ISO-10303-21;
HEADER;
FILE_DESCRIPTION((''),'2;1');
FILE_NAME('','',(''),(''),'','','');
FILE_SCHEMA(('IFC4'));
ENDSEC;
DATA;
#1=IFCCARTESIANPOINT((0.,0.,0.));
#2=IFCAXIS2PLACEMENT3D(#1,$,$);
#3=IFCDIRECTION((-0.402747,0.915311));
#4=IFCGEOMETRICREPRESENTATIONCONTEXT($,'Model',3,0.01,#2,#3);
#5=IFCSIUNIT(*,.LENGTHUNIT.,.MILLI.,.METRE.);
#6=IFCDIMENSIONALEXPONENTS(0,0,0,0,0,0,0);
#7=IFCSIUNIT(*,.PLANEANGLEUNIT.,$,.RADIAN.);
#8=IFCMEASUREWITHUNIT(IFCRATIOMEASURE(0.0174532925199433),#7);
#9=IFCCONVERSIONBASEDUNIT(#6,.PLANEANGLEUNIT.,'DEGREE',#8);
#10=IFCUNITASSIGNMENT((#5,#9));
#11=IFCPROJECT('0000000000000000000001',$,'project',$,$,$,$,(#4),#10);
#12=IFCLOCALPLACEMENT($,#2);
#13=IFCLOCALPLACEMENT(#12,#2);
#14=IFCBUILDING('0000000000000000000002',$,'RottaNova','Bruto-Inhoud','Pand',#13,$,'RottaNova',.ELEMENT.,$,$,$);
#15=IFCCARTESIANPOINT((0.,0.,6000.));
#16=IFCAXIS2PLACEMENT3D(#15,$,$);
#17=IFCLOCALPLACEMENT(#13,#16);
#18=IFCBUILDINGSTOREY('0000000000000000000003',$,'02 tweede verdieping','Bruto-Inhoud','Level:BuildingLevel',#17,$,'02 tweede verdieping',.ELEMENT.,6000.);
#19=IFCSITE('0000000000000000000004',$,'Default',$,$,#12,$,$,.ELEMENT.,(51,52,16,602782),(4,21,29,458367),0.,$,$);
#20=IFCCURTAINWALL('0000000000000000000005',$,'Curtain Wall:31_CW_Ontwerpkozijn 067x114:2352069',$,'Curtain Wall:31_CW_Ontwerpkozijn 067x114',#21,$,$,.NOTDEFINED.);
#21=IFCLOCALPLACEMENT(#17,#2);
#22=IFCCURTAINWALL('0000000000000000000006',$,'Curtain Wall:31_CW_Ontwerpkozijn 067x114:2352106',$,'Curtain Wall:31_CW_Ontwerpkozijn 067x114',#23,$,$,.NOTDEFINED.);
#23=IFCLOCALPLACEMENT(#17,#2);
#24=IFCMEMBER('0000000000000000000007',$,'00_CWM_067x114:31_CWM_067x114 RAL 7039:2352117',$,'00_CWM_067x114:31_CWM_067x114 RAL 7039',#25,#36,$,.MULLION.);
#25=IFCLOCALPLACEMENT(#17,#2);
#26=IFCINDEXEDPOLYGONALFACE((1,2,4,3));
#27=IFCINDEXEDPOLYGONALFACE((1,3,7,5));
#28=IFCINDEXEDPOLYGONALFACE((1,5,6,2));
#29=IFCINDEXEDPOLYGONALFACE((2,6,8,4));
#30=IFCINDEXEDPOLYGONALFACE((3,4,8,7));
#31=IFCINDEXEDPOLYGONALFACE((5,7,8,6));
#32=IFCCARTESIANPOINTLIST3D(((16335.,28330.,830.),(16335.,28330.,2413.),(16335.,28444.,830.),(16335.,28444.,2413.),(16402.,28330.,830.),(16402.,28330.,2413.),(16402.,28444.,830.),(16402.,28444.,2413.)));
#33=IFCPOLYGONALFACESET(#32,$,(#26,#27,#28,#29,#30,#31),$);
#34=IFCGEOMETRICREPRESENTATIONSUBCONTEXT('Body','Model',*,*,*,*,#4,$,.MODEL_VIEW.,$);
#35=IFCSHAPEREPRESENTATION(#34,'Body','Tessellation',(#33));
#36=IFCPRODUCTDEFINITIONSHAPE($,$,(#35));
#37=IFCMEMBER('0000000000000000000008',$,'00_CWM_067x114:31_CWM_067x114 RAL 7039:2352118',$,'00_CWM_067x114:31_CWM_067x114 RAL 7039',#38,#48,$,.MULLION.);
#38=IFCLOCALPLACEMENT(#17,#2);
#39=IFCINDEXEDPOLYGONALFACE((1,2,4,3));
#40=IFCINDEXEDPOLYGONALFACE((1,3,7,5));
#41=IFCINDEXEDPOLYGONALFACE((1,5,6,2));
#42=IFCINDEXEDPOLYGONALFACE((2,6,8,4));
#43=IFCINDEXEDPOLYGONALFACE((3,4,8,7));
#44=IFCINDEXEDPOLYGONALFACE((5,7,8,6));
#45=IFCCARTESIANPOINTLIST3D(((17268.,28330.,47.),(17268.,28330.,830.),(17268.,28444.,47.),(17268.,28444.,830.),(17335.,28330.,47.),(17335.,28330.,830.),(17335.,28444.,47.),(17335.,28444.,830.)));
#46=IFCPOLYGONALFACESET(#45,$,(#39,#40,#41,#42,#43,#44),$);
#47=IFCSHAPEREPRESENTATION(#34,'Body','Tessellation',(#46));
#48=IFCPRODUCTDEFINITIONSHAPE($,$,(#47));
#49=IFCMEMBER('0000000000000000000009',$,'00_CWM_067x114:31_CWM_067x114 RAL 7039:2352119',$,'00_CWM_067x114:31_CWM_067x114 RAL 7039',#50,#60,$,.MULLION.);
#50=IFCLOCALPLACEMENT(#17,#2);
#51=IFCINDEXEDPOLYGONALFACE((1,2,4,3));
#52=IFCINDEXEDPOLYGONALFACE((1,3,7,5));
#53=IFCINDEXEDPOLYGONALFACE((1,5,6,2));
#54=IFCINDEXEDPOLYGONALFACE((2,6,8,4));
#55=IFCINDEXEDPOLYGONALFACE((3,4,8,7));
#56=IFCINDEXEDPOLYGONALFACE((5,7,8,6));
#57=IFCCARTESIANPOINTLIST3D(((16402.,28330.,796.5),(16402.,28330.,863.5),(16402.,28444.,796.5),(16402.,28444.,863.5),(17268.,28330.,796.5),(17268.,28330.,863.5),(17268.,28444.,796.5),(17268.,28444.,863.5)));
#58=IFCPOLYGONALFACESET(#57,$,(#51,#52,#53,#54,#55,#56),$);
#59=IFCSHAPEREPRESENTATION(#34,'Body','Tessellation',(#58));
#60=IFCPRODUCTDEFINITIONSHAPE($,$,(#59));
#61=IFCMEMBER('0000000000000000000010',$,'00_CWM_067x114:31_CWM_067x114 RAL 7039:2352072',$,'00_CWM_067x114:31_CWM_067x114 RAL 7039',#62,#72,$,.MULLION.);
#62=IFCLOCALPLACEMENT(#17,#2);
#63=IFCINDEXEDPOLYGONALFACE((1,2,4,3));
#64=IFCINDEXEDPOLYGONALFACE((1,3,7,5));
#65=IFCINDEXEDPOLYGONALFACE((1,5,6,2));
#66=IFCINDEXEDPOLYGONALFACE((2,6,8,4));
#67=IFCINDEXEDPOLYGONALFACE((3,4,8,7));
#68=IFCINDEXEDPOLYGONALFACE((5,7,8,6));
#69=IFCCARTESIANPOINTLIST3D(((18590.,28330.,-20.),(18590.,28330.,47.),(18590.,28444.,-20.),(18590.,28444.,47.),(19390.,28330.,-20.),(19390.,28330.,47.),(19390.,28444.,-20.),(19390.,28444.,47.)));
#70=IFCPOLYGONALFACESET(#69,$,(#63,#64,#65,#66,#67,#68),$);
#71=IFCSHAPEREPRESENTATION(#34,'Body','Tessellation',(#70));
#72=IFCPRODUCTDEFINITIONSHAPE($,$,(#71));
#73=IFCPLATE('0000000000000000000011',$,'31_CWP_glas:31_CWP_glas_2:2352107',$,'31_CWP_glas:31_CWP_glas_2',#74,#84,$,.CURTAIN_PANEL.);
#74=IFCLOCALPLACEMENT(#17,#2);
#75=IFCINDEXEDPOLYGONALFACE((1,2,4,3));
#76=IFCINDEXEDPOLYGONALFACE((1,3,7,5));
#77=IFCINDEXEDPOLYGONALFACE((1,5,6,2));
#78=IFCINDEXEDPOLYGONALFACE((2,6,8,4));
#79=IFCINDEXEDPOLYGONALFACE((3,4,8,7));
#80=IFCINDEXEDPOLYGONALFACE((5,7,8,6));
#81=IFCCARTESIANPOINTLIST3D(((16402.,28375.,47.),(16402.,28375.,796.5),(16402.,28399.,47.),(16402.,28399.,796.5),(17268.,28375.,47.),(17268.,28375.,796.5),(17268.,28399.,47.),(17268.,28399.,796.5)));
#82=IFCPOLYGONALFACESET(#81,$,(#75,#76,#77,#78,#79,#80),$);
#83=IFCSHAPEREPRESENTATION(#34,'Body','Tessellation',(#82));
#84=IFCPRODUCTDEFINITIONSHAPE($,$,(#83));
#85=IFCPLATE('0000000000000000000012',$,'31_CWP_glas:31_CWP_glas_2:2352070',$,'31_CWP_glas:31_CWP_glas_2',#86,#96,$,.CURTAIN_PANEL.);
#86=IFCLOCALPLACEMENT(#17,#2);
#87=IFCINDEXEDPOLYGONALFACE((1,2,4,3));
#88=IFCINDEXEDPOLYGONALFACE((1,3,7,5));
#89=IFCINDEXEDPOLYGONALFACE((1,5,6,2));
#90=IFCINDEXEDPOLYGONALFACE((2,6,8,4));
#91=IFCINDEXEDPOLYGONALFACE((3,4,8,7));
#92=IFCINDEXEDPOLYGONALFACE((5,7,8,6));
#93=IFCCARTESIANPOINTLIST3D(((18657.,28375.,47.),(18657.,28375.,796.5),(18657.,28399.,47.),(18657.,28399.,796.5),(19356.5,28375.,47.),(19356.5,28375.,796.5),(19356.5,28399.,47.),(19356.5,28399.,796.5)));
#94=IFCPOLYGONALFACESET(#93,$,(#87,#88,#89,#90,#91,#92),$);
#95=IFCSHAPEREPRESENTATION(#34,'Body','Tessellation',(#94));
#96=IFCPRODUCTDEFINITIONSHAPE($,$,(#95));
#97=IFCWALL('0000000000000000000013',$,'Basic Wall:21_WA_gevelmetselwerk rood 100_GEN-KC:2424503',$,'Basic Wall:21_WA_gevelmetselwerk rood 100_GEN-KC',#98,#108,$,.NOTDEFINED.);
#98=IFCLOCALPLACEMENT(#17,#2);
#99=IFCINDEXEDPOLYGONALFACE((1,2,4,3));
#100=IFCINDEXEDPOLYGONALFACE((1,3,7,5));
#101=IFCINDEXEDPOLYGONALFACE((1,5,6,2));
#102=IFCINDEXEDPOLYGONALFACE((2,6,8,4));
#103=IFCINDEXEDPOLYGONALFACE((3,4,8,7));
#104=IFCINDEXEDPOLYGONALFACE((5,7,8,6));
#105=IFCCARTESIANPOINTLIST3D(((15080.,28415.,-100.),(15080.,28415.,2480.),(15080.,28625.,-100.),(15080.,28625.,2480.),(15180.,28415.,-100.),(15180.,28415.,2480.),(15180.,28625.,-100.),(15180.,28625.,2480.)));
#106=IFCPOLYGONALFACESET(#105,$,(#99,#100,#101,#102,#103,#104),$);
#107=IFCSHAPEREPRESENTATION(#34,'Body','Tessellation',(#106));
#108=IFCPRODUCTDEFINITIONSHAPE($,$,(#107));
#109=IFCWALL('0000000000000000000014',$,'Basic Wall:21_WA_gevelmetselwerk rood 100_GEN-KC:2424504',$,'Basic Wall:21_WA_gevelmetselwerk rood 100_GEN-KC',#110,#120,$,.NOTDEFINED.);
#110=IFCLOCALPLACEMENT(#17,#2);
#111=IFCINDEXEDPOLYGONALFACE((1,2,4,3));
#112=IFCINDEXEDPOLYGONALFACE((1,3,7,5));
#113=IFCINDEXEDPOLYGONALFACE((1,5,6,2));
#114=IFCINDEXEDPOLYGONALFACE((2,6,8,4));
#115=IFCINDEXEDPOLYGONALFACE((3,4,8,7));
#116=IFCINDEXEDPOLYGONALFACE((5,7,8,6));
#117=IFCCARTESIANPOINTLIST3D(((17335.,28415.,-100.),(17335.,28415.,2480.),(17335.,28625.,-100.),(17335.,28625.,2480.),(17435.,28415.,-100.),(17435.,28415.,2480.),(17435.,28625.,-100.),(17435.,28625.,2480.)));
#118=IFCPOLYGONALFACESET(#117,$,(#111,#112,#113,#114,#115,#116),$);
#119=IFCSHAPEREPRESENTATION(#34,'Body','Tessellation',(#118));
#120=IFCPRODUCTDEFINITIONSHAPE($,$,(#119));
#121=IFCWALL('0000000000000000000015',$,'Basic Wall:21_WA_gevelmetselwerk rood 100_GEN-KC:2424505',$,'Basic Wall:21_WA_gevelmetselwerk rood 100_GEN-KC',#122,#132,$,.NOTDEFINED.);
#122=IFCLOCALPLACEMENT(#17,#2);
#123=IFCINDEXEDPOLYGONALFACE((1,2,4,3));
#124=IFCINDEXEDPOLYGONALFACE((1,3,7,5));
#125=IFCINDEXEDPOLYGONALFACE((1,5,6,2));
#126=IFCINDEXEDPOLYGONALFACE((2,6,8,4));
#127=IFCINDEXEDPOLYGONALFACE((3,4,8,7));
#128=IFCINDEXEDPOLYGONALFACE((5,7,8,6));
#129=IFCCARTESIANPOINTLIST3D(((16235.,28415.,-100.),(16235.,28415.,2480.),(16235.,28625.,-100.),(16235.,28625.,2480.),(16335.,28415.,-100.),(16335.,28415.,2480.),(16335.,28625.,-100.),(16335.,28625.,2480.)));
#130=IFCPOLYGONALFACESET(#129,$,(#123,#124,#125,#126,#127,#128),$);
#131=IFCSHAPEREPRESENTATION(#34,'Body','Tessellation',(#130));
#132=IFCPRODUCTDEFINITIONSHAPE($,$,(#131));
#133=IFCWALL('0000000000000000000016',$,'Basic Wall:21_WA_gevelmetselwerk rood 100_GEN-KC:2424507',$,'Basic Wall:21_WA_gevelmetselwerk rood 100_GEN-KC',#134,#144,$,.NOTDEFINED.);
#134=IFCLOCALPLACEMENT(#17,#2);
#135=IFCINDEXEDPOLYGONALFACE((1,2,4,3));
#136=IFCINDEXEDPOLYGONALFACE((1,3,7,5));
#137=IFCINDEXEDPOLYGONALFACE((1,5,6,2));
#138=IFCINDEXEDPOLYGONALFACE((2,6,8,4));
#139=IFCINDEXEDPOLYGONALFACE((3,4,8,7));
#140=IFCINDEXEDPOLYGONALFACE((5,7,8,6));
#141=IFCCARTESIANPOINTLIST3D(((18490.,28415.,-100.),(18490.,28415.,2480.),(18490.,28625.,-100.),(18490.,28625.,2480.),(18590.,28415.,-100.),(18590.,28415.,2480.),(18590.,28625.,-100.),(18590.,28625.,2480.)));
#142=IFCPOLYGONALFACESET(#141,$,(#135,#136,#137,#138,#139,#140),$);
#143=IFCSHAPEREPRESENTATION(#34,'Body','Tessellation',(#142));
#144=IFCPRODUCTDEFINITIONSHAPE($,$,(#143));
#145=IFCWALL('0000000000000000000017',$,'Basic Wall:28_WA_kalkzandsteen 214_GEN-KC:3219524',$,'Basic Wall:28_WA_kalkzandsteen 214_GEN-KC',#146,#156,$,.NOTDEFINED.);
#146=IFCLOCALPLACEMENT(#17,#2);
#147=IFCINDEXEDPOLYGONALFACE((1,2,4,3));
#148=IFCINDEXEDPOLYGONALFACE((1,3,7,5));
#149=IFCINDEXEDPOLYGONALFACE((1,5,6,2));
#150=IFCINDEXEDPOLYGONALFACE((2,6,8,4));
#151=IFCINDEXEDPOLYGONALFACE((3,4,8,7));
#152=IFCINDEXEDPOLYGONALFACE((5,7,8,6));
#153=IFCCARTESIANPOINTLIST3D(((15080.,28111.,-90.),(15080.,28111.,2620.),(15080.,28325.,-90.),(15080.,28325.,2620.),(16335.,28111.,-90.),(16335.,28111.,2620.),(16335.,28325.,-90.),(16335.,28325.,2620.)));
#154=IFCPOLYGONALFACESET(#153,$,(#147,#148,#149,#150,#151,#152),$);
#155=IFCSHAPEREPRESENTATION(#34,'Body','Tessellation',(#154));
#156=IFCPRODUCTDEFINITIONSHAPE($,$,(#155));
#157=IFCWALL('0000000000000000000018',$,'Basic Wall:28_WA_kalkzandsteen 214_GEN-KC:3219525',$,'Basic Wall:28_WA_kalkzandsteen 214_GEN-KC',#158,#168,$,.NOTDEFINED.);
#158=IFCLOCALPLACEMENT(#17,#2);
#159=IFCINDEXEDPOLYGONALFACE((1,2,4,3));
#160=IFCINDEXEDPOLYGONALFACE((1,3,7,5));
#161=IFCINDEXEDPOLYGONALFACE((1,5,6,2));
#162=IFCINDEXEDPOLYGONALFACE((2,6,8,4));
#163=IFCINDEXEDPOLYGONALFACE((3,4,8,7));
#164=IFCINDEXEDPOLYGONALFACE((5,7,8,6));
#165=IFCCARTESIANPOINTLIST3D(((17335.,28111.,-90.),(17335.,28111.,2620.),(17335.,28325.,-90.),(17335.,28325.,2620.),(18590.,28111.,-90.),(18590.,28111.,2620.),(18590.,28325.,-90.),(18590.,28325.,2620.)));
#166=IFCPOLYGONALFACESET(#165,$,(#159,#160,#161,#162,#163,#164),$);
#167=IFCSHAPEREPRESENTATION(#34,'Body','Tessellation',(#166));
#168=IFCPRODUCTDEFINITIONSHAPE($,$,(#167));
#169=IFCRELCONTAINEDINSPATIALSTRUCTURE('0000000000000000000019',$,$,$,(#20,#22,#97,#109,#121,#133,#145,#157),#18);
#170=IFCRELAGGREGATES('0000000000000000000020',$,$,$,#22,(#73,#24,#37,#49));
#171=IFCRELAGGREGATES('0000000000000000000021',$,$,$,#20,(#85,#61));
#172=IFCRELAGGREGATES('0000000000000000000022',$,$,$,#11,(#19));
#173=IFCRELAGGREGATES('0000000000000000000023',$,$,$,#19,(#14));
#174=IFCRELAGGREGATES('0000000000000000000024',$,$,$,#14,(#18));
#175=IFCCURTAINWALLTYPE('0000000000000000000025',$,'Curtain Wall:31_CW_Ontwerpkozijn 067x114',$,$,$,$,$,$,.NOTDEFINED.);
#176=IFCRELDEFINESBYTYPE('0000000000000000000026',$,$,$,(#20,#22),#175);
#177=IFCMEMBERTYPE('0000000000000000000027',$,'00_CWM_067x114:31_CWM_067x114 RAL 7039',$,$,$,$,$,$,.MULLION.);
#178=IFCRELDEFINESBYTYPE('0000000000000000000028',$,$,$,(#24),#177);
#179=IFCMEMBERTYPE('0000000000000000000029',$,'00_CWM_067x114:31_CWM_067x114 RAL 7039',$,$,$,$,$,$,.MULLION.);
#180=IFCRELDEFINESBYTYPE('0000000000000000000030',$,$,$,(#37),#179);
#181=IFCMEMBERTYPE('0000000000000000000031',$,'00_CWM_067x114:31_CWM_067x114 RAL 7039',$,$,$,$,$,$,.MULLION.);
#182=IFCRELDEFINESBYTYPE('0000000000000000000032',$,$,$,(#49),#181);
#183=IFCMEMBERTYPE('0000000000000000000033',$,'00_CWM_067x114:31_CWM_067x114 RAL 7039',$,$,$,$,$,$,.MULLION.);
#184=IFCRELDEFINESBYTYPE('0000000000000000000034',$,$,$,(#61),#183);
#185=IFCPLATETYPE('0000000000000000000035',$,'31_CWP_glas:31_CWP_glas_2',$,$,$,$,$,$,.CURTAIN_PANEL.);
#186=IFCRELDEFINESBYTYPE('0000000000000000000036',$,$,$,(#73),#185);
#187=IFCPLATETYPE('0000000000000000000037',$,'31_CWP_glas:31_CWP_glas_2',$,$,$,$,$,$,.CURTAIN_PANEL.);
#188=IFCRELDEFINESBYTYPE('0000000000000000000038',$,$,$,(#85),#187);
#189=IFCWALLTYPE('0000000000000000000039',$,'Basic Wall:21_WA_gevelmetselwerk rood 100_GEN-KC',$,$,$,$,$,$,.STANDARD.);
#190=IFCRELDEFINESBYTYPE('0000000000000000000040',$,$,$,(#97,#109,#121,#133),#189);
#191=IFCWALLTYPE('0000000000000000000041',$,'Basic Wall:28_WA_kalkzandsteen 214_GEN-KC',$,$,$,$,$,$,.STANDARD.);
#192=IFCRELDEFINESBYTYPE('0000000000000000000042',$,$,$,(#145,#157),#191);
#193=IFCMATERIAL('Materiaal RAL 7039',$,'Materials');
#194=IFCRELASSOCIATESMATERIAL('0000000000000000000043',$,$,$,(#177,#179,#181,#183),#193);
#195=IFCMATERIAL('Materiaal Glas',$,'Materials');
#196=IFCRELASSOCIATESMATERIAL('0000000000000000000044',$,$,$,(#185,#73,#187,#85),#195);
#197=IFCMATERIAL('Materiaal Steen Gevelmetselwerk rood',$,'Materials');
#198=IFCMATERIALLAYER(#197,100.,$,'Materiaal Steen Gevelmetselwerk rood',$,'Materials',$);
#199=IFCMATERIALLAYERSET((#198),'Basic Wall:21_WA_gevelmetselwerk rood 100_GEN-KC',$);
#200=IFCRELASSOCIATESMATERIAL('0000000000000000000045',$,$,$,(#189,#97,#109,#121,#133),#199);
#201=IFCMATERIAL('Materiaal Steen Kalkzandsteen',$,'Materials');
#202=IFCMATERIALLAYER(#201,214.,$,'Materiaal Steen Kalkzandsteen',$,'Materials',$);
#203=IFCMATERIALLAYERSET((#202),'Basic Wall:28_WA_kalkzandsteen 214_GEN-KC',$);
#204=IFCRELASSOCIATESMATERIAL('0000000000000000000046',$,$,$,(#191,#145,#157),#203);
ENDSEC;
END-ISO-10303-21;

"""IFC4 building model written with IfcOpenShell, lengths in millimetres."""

from ifc_helpers import new_model, entity, si_unit, converted_unit, direction, frame, frame_2d, origin, origin_2d_with_axis, place, context, subcontext, project, spatial, rectangle, extrude, source, transform, mapped, material, layer, layer_set, material_profile, profile_set, type_object, type_shapes, element, aggregate, save


model = new_model("IFC4")

# Units and contexts
model_context = context("Model", 3, precision=0.01, world=origin(), true_north=direction((-0.402747, 0.915311)))
body_context = subcontext(model_context, "Body", "Model", "MODEL_VIEW")
ifc_project = project(units=[si_unit("LENGTHUNIT", "METRE", prefix="MILLI"), converted_unit("PLANEANGLEUNIT", "DEGREE", entity("IfcRatioMeasure", 0.0174532925199433), si_unit("PLANEANGLEUNIT", "RADIAN"), dimensions=[0, 0, 0, 0, 0, 0, 0])], contexts=[model_context])

# Site, building, storey
site_placement = place(None, origin())
site = spatial("IfcSite", under=ifc_project, at=site_placement, Name="Default", CompositionType="ELEMENT", RefLatitude=(51, 52, 16, 602782), RefLongitude=(4, 21, 29, 458367), RefElevation=0.0)
building_placement = place(site_placement, origin())
building = spatial("IfcBuilding", under=site, at=building_placement, Name="RottaNova", Description="Bruto-Inhoud", ObjectType="Pand", LongName="RottaNova", CompositionType="ELEMENT")
storey_placement = place(building_placement, frame((0.0, 0.0, 6000.0)))
storey = spatial("IfcBuildingStorey", under=building, at=storey_placement, Name="02 tweede verdieping", Description="Bruto-Inhoud", ObjectType="Level:BuildingLevel", LongName="02 tweede verdieping", CompositionType="ELEMENT", Elevation=6000.0)

# Shared definitions
curtain_wall_type = type_object("IfcCurtainWallType", Name="Curtain Wall:31_CW_Ontwerpkozijn 067x114", PredefinedType="NOTDEFINED")
ifc_material_1 = material(Name="Materiaal RAL 7039", Category="Materials")
ifc_material_profile = material_profile(ifc_material_1, rectangle(XDim=114.0, YDim=67.0, at=origin_2d_with_axis()), Name="31_CWM_067x114 RAL 7039")
ifc_profile_set = profile_set([ifc_material_profile], Name="31_CWM_067x114 RAL 7039")

# Curtain wall
curtain_wall_1_placement = place(storey_placement, frame((0.0, 0.0, -6000.0)))
curtain_wall_1 = element("IfcCurtainWall", 1, at=curtain_wall_1_placement, inside=storey, type_object=curtain_wall_type, Name="Curtain Wall:31_CW_Ontwerpkozijn 067x114:2352069", ObjectType="Curtain Wall:31_CW_Ontwerpkozijn 067x114", PredefinedType="NOTDEFINED")

# Curtain wall, members
curtain_wall_2_placement = place(storey_placement, frame((0.0, 0.0, -6000.0)))
curtain_wall_2 = element("IfcCurtainWall", 2, at=curtain_wall_2_placement, inside=storey, type_object=curtain_wall_type, Name="Curtain Wall:31_CW_Ontwerpkozijn 067x114:2352106", ObjectType="Curtain Wall:31_CW_Ontwerpkozijn 067x114", PredefinedType="NOTDEFINED")
member_type_1 = type_object("IfcMemberType", Name="00_CWM_067x114:31_CWM_067x114 RAL 7039", PredefinedType="MULLION", material=ifc_profile_set)
shared_shape_1 = source(origin(), body_context, "Body", "SweptSolid", [
    extrude(rectangle(XDim=114.0, YDim=67.0, at=origin_2d_with_axis()), frame((-33.5, 57.0, -1583.0), z_axis=(0.0, 0.0, 1.0), x_axis=(0.0, -1.0, 0.0)), (0.0, 0.0, 1.0), 1583.0),
])
type_shapes(member_type_1, [shared_shape_1])
member_1_placement = place(curtain_wall_2_placement, frame((16335.0, 28330.0, 6830.0), z_axis=(0.0, 0.0, -1.0), x_axis=(-1.0, 0.0, 0.0)))
member_1 = element("IfcMember", 3, at=member_1_placement, type_object=member_type_1, Name="00_CWM_067x114:31_CWM_067x114 RAL 7039:2352117", ObjectType="00_CWM_067x114:31_CWM_067x114 RAL 7039", PredefinedType="MULLION", context=body_context, shape_type="MappedRepresentation", body=[
    mapped(shared_shape_1, transform((0.0, 0.0, 0.0), scale=1.0)),
])
member_type_2 = type_object("IfcMemberType", Name="00_CWM_067x114:31_CWM_067x114 RAL 7039", PredefinedType="MULLION", material=ifc_profile_set)
shared_shape_2 = source(origin(), body_context, "Body", "SweptSolid", [
    extrude(rectangle(XDim=114.0, YDim=67.0, at=origin_2d_with_axis()), frame((-33.5, 57.0, -783.0), z_axis=(0.0, 0.0, 1.0), x_axis=(0.0, -1.0, 0.0)), (0.0, 0.0, 1.0), 783.0),
])
type_shapes(member_type_2, [shared_shape_2])
member_2_placement = place(curtain_wall_2_placement, frame((17335.0, 28330.0, 6830.0)))
member_2 = element("IfcMember", 4, at=member_2_placement, type_object=member_type_2, Name="00_CWM_067x114:31_CWM_067x114 RAL 7039:2352118", ObjectType="00_CWM_067x114:31_CWM_067x114 RAL 7039", PredefinedType="MULLION", context=body_context, shape_type="MappedRepresentation", body=[
    mapped(shared_shape_2, transform((0.0, 0.0, 0.0), scale=1.0)),
])
member_type_3 = type_object("IfcMemberType", Name="00_CWM_067x114:31_CWM_067x114 RAL 7039", PredefinedType="MULLION", material=ifc_profile_set)
shared_shape_3 = source(origin(), body_context, "Body", "SweptSolid", [
    extrude(rectangle(XDim=114.0, YDim=67.0, at=origin_2d_with_axis()), frame((0.0, 57.0, -866.0), z_axis=(0.0, 0.0, 1.0), x_axis=(0.0, -1.0, 0.0)), (0.0, 0.0, 1.0), 866.0),
])
type_shapes(member_type_3, [shared_shape_3])
member_3_placement = place(curtain_wall_2_placement, frame((16402.0, 28330.0, 6830.0), z_axis=(-1.0, 0.0, 0.0), x_axis=(0.0, 0.0, 1.0)))
member_3 = element("IfcMember", 5, at=member_3_placement, type_object=member_type_3, Name="00_CWM_067x114:31_CWM_067x114 RAL 7039:2352119", ObjectType="00_CWM_067x114:31_CWM_067x114 RAL 7039", PredefinedType="MULLION", context=body_context, shape_type="MappedRepresentation", body=[
    mapped(shared_shape_3, transform((0.0, 0.0, 0.0), scale=1.0)),
])

# Member
member_type_4 = type_object("IfcMemberType", Name="00_CWM_067x114:31_CWM_067x114 RAL 7039", PredefinedType="MULLION", material=ifc_profile_set)
shared_shape_4 = source(origin(), body_context, "Body", "SweptSolid", [
    extrude(rectangle(XDim=114.0, YDim=67.0, at=frame_2d((0.0, 0.0), x_axis=(1.0, 0.0))), frame((-33.5, -57.0, -800.0), z_axis=(0.0, 0.0, 1.0), x_axis=(0.0, -1.0, 0.0)), (0.0, 0.0, 1.0), 800.0),
])
type_shapes(member_type_4, [shared_shape_4])
member_4_placement = place(curtain_wall_1_placement, frame((18590.0, 28330.0, 5980.0), z_axis=(-1.0, 0.0, 0.0), x_axis=(0.0, 0.0, -1.0)))
member_4 = element("IfcMember", 6, at=member_4_placement, type_object=member_type_4, Name="00_CWM_067x114:31_CWM_067x114 RAL 7039:2352072", ObjectType="00_CWM_067x114:31_CWM_067x114 RAL 7039", PredefinedType="MULLION", context=body_context, shape_type="MappedRepresentation", body=[
    mapped(shared_shape_4, transform((0.0, 0.0, 0.0), scale=1.0)),
])

# Plates
ifc_material_2 = material(Name="Materiaal Glas", Category="Materials")
plate_type_1 = type_object("IfcPlateType", Name="31_CWP_glas:31_CWP_glas_2", PredefinedType="CURTAIN_PANEL", material=ifc_material_2)
shared_shape_5 = source(origin(), body_context, "Body", "SweptSolid", [
    extrude(rectangle(XDim=24.0, YDim=866.0, at=frame_2d((0.0, 0.0), x_axis=(1.0, 0.0))), frame((433.0, 12.0, 0.0), z_axis=(0.0, 0.0, 1.0), x_axis=(0.0, 1.0, 0.0)), (0.0, 0.0, 1.0), 749.5),
])
type_shapes(plate_type_1, [shared_shape_5])
plate_1_placement = place(curtain_wall_2_placement, frame((17268.0, 28399.0, 6047.0), z_axis=(0.0, 0.0, 1.0), x_axis=(-1.0, 0.0, 0.0)))
plate_1 = element("IfcPlate", 7, at=plate_1_placement, type_object=plate_type_1, material=ifc_material_2, Name="31_CWP_glas:31_CWP_glas_2:2352107", ObjectType="31_CWP_glas:31_CWP_glas_2", PredefinedType="CURTAIN_PANEL", context=body_context, shape_type="MappedRepresentation", body=[
    mapped(shared_shape_5, transform((0.0, 0.0, 0.0), scale=1.0)),
])
plate_type_2 = type_object("IfcPlateType", Name="31_CWP_glas:31_CWP_glas_2", PredefinedType="CURTAIN_PANEL", material=ifc_material_2)
shared_shape_6 = source(origin(), body_context, "Body", "SweptSolid", [
    extrude(rectangle(XDim=24.0, YDim=699.5, at=frame_2d((0.0, 0.0), x_axis=(1.0, 0.0))), frame((349.8, 12.0, 0.0), z_axis=(0.0, 0.0, 1.0), x_axis=(0.0, 1.0, 0.0)), (0.0, 0.0, 1.0), 749.5),
])
type_shapes(plate_type_2, [shared_shape_6])
plate_2_placement = place(curtain_wall_1_placement, frame((18657.0, 28375.0, 6047.0)))
plate_2 = element("IfcPlate", 8, at=plate_2_placement, type_object=plate_type_2, material=ifc_material_2, Name="31_CWP_glas:31_CWP_glas_2:2352070", ObjectType="31_CWP_glas:31_CWP_glas_2", PredefinedType="CURTAIN_PANEL", context=body_context, shape_type="MappedRepresentation", body=[
    mapped(shared_shape_6, transform((0.0, 0.0, 0.0), scale=1.0)),
])

# Walls
ifc_material_3 = material(Name="Materiaal Steen Gevelmetselwerk rood", Category="Materials")
ifc_layer_1 = layer(ifc_material_3, 100.0, Name="Materiaal Steen Gevelmetselwerk rood", Category="Materials")
ifc_layer_set_1 = layer_set([ifc_layer_1], Name="Basic Wall:21_WA_gevelmetselwerk rood 100_GEN-KC")
wall_type_1 = type_object("IfcWallType", Name="Basic Wall:21_WA_gevelmetselwerk rood 100_GEN-KC", PredefinedType="STANDARD", material=ifc_layer_set_1)
for number, where, z_axis, x_axis, name in (
    (9, (15130.0, 28415.0, -100.0), (0.0, 0.0, 1.0), (0.0, 1.0, 0.0), "Basic Wall:21_WA_gevelmetselwerk rood 100_GEN-KC:2424503"),
    (10, (17385.0, 28415.0, -100.0), (0.0, 0.0, 1.0), (0.0, 1.0, 0.0), "Basic Wall:21_WA_gevelmetselwerk rood 100_GEN-KC:2424504"),
    (11, (16285.0, 28415.0, -100.0), (0.0, 0.0, 1.0), (0.0, 1.0, 0.0), "Basic Wall:21_WA_gevelmetselwerk rood 100_GEN-KC:2424505"),
):
    element("IfcWall", number, at=place(storey_placement, frame(where, z_axis=z_axis, x_axis=x_axis)), inside=storey, type_object=wall_type_1, material=ifc_layer_set_1, Name=name, ObjectType="Basic Wall:21_WA_gevelmetselwerk rood 100_GEN-KC", PredefinedType="NOTDEFINED", context=body_context, shape_type="SweptSolid", body=[
        extrude(rectangle(XDim=210.0, YDim=100.0, at=frame_2d((105.0, 0.0), x_axis=(-1.0, 0.0))), origin(), (0.0, 0.0, 1.0), 2580.0),
    ])
wall_1_placement = place(storey_placement, frame((18540.0, 28415.0, -100.0), z_axis=(0.0, 0.0, 1.0), x_axis=(0.0, 1.0, 0.0)))
element("IfcWall", 12, at=wall_1_placement, inside=storey, type_object=wall_type_1, material=ifc_layer_set_1, Name="Basic Wall:21_WA_gevelmetselwerk rood 100_GEN-KC:2424507", ObjectType="Basic Wall:21_WA_gevelmetselwerk rood 100_GEN-KC", PredefinedType="NOTDEFINED", context=body_context, shape_type="SweptSolid", body=[
    extrude(rectangle(XDim=210.0, YDim=100.0, at=frame_2d((105.0, 0.0), x_axis=(-1.0, 0.0))), origin(), (0.0, 0.0, 1.0), 2580.0),
])

# Walls
ifc_material_4 = material(Name="Materiaal Steen Kalkzandsteen", Category="Materials")
ifc_layer_2 = layer(ifc_material_4, 214.0, Name="Materiaal Steen Kalkzandsteen", Category="Materials")
ifc_layer_set_2 = layer_set([ifc_layer_2], Name="Basic Wall:28_WA_kalkzandsteen 214_GEN-KC")
wall_type_2 = type_object("IfcWallType", Name="Basic Wall:28_WA_kalkzandsteen 214_GEN-KC", PredefinedType="STANDARD", material=ifc_layer_set_2)
wall_2_placement = place(storey_placement, frame((15080.0, 28218.0, -90.0)))
element("IfcWall", 13, at=wall_2_placement, inside=storey, type_object=wall_type_2, material=ifc_layer_set_2, Name="Basic Wall:28_WA_kalkzandsteen 214_GEN-KC:3219524", ObjectType="Basic Wall:28_WA_kalkzandsteen 214_GEN-KC", PredefinedType="NOTDEFINED", context=body_context, shape_type="SweptSolid", body=[
    extrude(rectangle(XDim=1255.0, YDim=214.0, at=frame_2d((627.5, 0.0), x_axis=(-1.0, 0.0))), origin(), (0.0, 0.0, 1.0), 2710.0),
])
wall_3_placement = place(storey_placement, frame((17335.0, 28218.0, -90.0)))
element("IfcWall", 14, at=wall_3_placement, inside=storey, type_object=wall_type_2, material=ifc_layer_set_2, Name="Basic Wall:28_WA_kalkzandsteen 214_GEN-KC:3219525", ObjectType="Basic Wall:28_WA_kalkzandsteen 214_GEN-KC", PredefinedType="NOTDEFINED", context=body_context, shape_type="SweptSolid", body=[
    extrude(rectangle(XDim=1255.0, YDim=214.0, at=frame_2d((627.5, 0.0), x_axis=(-1.0, 0.0))), origin(), (0.0, 0.0, 1.0), 2710.0),
])

aggregate(curtain_wall_2, [plate_1, member_1, member_2, member_3])
aggregate(curtain_wall_1, [plate_2, member_4])

save(model, "model.ifc")
